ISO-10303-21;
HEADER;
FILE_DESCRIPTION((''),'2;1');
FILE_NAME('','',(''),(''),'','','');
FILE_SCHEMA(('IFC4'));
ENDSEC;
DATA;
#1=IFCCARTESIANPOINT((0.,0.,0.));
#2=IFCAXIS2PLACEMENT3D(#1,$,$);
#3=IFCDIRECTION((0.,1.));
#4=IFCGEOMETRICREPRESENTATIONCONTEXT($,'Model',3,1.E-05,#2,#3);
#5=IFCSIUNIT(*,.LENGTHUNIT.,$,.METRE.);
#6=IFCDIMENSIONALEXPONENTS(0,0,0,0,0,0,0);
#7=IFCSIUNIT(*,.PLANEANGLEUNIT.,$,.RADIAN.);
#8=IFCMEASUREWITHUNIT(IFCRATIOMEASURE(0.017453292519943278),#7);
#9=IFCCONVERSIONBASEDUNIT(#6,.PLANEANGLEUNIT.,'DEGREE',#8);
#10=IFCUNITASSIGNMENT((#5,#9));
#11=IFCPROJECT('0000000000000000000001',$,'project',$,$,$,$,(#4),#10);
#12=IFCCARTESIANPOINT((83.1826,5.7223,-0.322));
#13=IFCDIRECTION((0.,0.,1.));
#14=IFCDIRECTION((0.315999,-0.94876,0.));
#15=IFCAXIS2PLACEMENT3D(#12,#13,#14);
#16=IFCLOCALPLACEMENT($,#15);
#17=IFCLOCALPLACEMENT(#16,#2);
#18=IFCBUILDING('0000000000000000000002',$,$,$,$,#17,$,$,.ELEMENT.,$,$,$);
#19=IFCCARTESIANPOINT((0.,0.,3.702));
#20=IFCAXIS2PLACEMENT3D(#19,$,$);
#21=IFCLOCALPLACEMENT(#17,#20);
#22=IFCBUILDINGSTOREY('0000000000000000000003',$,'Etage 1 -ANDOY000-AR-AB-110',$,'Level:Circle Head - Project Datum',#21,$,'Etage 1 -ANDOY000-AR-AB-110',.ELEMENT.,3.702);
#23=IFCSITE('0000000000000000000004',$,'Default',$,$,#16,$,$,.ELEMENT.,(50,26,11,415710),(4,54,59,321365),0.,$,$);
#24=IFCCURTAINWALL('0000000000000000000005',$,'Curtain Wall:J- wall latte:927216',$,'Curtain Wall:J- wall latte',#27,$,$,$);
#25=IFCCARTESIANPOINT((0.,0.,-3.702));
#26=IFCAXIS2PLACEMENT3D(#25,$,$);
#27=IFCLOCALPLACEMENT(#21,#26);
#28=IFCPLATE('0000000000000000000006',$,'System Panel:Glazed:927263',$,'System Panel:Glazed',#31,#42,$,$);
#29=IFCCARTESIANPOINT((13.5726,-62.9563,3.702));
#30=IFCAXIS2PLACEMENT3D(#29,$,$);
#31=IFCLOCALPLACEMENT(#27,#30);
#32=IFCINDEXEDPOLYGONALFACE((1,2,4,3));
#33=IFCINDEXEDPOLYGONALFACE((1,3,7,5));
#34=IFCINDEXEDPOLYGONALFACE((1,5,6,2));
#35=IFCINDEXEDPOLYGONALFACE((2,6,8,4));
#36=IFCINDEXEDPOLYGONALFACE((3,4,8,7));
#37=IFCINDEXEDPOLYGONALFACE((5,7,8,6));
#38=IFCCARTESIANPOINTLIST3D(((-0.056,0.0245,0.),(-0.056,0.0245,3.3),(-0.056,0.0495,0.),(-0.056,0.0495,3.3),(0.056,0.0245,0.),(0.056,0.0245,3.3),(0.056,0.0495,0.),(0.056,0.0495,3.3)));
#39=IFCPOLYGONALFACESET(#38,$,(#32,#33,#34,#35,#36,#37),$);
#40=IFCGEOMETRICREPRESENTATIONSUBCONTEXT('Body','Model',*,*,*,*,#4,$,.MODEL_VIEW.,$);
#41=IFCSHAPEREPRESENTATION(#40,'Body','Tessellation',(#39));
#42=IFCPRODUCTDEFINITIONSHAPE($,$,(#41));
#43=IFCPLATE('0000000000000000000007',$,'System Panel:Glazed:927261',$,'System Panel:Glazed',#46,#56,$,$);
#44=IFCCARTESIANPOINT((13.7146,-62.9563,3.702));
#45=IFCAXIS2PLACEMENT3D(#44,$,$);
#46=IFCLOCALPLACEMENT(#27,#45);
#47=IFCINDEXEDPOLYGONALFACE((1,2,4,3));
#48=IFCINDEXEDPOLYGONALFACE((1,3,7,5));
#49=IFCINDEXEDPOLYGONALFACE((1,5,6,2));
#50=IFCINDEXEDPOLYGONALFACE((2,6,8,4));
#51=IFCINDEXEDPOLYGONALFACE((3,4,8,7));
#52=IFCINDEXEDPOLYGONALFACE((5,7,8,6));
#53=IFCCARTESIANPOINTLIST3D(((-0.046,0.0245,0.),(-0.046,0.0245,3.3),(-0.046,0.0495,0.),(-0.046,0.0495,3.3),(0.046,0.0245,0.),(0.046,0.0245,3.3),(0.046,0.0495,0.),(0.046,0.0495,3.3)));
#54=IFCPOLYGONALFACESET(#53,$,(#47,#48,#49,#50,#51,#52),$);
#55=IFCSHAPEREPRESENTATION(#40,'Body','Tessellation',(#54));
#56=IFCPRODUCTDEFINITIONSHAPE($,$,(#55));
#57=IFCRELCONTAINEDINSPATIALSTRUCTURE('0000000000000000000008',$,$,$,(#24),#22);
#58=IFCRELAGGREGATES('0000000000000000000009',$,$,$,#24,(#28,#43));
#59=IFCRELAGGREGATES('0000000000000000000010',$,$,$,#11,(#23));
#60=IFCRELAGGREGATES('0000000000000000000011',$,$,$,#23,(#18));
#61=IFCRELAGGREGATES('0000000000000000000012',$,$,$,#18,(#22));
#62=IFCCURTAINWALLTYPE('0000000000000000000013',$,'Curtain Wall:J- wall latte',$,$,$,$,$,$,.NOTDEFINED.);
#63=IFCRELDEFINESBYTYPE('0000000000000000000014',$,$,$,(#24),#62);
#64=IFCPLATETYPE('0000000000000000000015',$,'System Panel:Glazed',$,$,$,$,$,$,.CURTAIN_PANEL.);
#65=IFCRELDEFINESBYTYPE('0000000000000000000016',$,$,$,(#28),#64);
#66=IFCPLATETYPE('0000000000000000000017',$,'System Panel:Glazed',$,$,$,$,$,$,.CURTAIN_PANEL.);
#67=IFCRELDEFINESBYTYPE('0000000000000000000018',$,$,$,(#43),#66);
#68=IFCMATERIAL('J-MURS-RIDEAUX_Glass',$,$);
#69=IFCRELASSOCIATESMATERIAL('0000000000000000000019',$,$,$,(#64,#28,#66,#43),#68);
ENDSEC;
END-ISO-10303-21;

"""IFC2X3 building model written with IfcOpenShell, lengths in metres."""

from ifc_helpers import new_model, entity, si_unit, converted_unit, direction, frame, frame_2d, origin, place, context, subcontext, project, spatial, rectangle, extrude, source, transform, mapped, material, type_object, type_shapes, element, aggregate, save


model = new_model("IFC2X3")

# Units and contexts
model_context = context("Model", 3, precision=1e-05, world=origin(), true_north=direction((0.0, 1.0)))
body_context = subcontext(model_context, "Body", "Model", "MODEL_VIEW")
ifc_project = project(units=[si_unit("LENGTHUNIT", "METRE"), converted_unit("PLANEANGLEUNIT", "DEGREE", entity("IfcRatioMeasure", 0.017453292519943278), si_unit("PLANEANGLEUNIT", "RADIAN"), dimensions=[0, 0, 0, 0, 0, 0, 0])], contexts=[model_context])

# Site, building, storey
site_placement = place(None, frame((83.1826, 5.7223, -0.322), z_axis=(0.0, 0.0, 1.0), x_axis=(0.315999, -0.94876, 0.0)))
site = spatial("IfcSite", under=ifc_project, at=site_placement, Name="Default", CompositionType="ELEMENT", RefLatitude=(50, 26, 11, 415710), RefLongitude=(4, 54, 59, 321365), RefElevation=0.0)
building_placement = place(site_placement, origin())
building = spatial("IfcBuilding", under=site, at=building_placement, CompositionType="ELEMENT")
storey_placement = place(building_placement, frame((0.0, 0.0, 3.702)))
storey = spatial("IfcBuildingStorey", under=building, at=storey_placement, Name="Etage 1 -ANDOY000-AR-AB-110", ObjectType="Level:Circle Head - Project Datum", LongName="Etage 1 -ANDOY000-AR-AB-110", CompositionType="ELEMENT", Elevation=3.702)

# Curtain wall, plates
curtain_wall_type = type_object("IfcCurtainWallType", Name="Curtain Wall:J- wall latte", PredefinedType="NOTDEFINED")
curtain_wall_placement = place(storey_placement, frame((0.0, 0.0, -3.702)))
curtain_wall = element("IfcCurtainWall", 1, at=curtain_wall_placement, inside=storey, type_object=curtain_wall_type, Name="Curtain Wall:J- wall latte:927216", ObjectType="Curtain Wall:J- wall latte")
ifc_material_1 = material(Name="J-MURS-RIDEAUX_Glass")
plate_type_1 = type_object("IfcPlateType", Name="System Panel:Glazed", PredefinedType="CURTAIN_PANEL", material=ifc_material_1)
shared_shape_1 = source(origin(), body_context, "Body", "SweptSolid", [
    extrude(rectangle(XDim=0.025, YDim=0.112, at=frame_2d((0.0, 0.0), x_axis=(1.0, 0.0))), frame((0.0, 0.037, 0.0), z_axis=(0.0, 0.0, 1.0), x_axis=(0.0, 1.0, 0.0)), (0.0, 0.0, 1.0), 3.3),
])
type_shapes(plate_type_1, [shared_shape_1])
plate_1_placement = place(curtain_wall_placement, frame((13.5726, -62.9563, 3.702)))
plate_1 = element("IfcPlate", 2, at=plate_1_placement, type_object=plate_type_1, material=ifc_material_1, Name="System Panel:Glazed:927263", ObjectType="System Panel:Glazed", context=body_context, shape_type="MappedRepresentation", body=[
    mapped(shared_shape_1, transform((0.0, 0.0, 0.0), scale=1.0)),
])
plate_type_2 = type_object("IfcPlateType", Name="System Panel:Glazed", PredefinedType="CURTAIN_PANEL", material=ifc_material_1)
shared_shape_2 = source(origin(), body_context, "Body", "SweptSolid", [
    extrude(rectangle(XDim=0.025, YDim=0.092, at=frame_2d((0.0, 0.0), x_axis=(1.0, 0.0))), frame((0.0, 0.037, 0.0), z_axis=(0.0, 0.0, 1.0), x_axis=(0.0, 1.0, 0.0)), (0.0, 0.0, 1.0), 3.3),
])
type_shapes(plate_type_2, [shared_shape_2])
plate_2_placement = place(curtain_wall_placement, frame((13.7146, -62.9563, 3.702)))
plate_2 = element("IfcPlate", 3, at=plate_2_placement, type_object=plate_type_2, material=ifc_material_1, Name="System Panel:Glazed:927261", ObjectType="System Panel:Glazed", context=body_context, shape_type="MappedRepresentation", body=[
    mapped(shared_shape_2, transform((0.0, 0.0, 0.0), scale=1.0)),
])
aggregate(curtain_wall, [plate_1, plate_2])

save(model, "model.ifc")
